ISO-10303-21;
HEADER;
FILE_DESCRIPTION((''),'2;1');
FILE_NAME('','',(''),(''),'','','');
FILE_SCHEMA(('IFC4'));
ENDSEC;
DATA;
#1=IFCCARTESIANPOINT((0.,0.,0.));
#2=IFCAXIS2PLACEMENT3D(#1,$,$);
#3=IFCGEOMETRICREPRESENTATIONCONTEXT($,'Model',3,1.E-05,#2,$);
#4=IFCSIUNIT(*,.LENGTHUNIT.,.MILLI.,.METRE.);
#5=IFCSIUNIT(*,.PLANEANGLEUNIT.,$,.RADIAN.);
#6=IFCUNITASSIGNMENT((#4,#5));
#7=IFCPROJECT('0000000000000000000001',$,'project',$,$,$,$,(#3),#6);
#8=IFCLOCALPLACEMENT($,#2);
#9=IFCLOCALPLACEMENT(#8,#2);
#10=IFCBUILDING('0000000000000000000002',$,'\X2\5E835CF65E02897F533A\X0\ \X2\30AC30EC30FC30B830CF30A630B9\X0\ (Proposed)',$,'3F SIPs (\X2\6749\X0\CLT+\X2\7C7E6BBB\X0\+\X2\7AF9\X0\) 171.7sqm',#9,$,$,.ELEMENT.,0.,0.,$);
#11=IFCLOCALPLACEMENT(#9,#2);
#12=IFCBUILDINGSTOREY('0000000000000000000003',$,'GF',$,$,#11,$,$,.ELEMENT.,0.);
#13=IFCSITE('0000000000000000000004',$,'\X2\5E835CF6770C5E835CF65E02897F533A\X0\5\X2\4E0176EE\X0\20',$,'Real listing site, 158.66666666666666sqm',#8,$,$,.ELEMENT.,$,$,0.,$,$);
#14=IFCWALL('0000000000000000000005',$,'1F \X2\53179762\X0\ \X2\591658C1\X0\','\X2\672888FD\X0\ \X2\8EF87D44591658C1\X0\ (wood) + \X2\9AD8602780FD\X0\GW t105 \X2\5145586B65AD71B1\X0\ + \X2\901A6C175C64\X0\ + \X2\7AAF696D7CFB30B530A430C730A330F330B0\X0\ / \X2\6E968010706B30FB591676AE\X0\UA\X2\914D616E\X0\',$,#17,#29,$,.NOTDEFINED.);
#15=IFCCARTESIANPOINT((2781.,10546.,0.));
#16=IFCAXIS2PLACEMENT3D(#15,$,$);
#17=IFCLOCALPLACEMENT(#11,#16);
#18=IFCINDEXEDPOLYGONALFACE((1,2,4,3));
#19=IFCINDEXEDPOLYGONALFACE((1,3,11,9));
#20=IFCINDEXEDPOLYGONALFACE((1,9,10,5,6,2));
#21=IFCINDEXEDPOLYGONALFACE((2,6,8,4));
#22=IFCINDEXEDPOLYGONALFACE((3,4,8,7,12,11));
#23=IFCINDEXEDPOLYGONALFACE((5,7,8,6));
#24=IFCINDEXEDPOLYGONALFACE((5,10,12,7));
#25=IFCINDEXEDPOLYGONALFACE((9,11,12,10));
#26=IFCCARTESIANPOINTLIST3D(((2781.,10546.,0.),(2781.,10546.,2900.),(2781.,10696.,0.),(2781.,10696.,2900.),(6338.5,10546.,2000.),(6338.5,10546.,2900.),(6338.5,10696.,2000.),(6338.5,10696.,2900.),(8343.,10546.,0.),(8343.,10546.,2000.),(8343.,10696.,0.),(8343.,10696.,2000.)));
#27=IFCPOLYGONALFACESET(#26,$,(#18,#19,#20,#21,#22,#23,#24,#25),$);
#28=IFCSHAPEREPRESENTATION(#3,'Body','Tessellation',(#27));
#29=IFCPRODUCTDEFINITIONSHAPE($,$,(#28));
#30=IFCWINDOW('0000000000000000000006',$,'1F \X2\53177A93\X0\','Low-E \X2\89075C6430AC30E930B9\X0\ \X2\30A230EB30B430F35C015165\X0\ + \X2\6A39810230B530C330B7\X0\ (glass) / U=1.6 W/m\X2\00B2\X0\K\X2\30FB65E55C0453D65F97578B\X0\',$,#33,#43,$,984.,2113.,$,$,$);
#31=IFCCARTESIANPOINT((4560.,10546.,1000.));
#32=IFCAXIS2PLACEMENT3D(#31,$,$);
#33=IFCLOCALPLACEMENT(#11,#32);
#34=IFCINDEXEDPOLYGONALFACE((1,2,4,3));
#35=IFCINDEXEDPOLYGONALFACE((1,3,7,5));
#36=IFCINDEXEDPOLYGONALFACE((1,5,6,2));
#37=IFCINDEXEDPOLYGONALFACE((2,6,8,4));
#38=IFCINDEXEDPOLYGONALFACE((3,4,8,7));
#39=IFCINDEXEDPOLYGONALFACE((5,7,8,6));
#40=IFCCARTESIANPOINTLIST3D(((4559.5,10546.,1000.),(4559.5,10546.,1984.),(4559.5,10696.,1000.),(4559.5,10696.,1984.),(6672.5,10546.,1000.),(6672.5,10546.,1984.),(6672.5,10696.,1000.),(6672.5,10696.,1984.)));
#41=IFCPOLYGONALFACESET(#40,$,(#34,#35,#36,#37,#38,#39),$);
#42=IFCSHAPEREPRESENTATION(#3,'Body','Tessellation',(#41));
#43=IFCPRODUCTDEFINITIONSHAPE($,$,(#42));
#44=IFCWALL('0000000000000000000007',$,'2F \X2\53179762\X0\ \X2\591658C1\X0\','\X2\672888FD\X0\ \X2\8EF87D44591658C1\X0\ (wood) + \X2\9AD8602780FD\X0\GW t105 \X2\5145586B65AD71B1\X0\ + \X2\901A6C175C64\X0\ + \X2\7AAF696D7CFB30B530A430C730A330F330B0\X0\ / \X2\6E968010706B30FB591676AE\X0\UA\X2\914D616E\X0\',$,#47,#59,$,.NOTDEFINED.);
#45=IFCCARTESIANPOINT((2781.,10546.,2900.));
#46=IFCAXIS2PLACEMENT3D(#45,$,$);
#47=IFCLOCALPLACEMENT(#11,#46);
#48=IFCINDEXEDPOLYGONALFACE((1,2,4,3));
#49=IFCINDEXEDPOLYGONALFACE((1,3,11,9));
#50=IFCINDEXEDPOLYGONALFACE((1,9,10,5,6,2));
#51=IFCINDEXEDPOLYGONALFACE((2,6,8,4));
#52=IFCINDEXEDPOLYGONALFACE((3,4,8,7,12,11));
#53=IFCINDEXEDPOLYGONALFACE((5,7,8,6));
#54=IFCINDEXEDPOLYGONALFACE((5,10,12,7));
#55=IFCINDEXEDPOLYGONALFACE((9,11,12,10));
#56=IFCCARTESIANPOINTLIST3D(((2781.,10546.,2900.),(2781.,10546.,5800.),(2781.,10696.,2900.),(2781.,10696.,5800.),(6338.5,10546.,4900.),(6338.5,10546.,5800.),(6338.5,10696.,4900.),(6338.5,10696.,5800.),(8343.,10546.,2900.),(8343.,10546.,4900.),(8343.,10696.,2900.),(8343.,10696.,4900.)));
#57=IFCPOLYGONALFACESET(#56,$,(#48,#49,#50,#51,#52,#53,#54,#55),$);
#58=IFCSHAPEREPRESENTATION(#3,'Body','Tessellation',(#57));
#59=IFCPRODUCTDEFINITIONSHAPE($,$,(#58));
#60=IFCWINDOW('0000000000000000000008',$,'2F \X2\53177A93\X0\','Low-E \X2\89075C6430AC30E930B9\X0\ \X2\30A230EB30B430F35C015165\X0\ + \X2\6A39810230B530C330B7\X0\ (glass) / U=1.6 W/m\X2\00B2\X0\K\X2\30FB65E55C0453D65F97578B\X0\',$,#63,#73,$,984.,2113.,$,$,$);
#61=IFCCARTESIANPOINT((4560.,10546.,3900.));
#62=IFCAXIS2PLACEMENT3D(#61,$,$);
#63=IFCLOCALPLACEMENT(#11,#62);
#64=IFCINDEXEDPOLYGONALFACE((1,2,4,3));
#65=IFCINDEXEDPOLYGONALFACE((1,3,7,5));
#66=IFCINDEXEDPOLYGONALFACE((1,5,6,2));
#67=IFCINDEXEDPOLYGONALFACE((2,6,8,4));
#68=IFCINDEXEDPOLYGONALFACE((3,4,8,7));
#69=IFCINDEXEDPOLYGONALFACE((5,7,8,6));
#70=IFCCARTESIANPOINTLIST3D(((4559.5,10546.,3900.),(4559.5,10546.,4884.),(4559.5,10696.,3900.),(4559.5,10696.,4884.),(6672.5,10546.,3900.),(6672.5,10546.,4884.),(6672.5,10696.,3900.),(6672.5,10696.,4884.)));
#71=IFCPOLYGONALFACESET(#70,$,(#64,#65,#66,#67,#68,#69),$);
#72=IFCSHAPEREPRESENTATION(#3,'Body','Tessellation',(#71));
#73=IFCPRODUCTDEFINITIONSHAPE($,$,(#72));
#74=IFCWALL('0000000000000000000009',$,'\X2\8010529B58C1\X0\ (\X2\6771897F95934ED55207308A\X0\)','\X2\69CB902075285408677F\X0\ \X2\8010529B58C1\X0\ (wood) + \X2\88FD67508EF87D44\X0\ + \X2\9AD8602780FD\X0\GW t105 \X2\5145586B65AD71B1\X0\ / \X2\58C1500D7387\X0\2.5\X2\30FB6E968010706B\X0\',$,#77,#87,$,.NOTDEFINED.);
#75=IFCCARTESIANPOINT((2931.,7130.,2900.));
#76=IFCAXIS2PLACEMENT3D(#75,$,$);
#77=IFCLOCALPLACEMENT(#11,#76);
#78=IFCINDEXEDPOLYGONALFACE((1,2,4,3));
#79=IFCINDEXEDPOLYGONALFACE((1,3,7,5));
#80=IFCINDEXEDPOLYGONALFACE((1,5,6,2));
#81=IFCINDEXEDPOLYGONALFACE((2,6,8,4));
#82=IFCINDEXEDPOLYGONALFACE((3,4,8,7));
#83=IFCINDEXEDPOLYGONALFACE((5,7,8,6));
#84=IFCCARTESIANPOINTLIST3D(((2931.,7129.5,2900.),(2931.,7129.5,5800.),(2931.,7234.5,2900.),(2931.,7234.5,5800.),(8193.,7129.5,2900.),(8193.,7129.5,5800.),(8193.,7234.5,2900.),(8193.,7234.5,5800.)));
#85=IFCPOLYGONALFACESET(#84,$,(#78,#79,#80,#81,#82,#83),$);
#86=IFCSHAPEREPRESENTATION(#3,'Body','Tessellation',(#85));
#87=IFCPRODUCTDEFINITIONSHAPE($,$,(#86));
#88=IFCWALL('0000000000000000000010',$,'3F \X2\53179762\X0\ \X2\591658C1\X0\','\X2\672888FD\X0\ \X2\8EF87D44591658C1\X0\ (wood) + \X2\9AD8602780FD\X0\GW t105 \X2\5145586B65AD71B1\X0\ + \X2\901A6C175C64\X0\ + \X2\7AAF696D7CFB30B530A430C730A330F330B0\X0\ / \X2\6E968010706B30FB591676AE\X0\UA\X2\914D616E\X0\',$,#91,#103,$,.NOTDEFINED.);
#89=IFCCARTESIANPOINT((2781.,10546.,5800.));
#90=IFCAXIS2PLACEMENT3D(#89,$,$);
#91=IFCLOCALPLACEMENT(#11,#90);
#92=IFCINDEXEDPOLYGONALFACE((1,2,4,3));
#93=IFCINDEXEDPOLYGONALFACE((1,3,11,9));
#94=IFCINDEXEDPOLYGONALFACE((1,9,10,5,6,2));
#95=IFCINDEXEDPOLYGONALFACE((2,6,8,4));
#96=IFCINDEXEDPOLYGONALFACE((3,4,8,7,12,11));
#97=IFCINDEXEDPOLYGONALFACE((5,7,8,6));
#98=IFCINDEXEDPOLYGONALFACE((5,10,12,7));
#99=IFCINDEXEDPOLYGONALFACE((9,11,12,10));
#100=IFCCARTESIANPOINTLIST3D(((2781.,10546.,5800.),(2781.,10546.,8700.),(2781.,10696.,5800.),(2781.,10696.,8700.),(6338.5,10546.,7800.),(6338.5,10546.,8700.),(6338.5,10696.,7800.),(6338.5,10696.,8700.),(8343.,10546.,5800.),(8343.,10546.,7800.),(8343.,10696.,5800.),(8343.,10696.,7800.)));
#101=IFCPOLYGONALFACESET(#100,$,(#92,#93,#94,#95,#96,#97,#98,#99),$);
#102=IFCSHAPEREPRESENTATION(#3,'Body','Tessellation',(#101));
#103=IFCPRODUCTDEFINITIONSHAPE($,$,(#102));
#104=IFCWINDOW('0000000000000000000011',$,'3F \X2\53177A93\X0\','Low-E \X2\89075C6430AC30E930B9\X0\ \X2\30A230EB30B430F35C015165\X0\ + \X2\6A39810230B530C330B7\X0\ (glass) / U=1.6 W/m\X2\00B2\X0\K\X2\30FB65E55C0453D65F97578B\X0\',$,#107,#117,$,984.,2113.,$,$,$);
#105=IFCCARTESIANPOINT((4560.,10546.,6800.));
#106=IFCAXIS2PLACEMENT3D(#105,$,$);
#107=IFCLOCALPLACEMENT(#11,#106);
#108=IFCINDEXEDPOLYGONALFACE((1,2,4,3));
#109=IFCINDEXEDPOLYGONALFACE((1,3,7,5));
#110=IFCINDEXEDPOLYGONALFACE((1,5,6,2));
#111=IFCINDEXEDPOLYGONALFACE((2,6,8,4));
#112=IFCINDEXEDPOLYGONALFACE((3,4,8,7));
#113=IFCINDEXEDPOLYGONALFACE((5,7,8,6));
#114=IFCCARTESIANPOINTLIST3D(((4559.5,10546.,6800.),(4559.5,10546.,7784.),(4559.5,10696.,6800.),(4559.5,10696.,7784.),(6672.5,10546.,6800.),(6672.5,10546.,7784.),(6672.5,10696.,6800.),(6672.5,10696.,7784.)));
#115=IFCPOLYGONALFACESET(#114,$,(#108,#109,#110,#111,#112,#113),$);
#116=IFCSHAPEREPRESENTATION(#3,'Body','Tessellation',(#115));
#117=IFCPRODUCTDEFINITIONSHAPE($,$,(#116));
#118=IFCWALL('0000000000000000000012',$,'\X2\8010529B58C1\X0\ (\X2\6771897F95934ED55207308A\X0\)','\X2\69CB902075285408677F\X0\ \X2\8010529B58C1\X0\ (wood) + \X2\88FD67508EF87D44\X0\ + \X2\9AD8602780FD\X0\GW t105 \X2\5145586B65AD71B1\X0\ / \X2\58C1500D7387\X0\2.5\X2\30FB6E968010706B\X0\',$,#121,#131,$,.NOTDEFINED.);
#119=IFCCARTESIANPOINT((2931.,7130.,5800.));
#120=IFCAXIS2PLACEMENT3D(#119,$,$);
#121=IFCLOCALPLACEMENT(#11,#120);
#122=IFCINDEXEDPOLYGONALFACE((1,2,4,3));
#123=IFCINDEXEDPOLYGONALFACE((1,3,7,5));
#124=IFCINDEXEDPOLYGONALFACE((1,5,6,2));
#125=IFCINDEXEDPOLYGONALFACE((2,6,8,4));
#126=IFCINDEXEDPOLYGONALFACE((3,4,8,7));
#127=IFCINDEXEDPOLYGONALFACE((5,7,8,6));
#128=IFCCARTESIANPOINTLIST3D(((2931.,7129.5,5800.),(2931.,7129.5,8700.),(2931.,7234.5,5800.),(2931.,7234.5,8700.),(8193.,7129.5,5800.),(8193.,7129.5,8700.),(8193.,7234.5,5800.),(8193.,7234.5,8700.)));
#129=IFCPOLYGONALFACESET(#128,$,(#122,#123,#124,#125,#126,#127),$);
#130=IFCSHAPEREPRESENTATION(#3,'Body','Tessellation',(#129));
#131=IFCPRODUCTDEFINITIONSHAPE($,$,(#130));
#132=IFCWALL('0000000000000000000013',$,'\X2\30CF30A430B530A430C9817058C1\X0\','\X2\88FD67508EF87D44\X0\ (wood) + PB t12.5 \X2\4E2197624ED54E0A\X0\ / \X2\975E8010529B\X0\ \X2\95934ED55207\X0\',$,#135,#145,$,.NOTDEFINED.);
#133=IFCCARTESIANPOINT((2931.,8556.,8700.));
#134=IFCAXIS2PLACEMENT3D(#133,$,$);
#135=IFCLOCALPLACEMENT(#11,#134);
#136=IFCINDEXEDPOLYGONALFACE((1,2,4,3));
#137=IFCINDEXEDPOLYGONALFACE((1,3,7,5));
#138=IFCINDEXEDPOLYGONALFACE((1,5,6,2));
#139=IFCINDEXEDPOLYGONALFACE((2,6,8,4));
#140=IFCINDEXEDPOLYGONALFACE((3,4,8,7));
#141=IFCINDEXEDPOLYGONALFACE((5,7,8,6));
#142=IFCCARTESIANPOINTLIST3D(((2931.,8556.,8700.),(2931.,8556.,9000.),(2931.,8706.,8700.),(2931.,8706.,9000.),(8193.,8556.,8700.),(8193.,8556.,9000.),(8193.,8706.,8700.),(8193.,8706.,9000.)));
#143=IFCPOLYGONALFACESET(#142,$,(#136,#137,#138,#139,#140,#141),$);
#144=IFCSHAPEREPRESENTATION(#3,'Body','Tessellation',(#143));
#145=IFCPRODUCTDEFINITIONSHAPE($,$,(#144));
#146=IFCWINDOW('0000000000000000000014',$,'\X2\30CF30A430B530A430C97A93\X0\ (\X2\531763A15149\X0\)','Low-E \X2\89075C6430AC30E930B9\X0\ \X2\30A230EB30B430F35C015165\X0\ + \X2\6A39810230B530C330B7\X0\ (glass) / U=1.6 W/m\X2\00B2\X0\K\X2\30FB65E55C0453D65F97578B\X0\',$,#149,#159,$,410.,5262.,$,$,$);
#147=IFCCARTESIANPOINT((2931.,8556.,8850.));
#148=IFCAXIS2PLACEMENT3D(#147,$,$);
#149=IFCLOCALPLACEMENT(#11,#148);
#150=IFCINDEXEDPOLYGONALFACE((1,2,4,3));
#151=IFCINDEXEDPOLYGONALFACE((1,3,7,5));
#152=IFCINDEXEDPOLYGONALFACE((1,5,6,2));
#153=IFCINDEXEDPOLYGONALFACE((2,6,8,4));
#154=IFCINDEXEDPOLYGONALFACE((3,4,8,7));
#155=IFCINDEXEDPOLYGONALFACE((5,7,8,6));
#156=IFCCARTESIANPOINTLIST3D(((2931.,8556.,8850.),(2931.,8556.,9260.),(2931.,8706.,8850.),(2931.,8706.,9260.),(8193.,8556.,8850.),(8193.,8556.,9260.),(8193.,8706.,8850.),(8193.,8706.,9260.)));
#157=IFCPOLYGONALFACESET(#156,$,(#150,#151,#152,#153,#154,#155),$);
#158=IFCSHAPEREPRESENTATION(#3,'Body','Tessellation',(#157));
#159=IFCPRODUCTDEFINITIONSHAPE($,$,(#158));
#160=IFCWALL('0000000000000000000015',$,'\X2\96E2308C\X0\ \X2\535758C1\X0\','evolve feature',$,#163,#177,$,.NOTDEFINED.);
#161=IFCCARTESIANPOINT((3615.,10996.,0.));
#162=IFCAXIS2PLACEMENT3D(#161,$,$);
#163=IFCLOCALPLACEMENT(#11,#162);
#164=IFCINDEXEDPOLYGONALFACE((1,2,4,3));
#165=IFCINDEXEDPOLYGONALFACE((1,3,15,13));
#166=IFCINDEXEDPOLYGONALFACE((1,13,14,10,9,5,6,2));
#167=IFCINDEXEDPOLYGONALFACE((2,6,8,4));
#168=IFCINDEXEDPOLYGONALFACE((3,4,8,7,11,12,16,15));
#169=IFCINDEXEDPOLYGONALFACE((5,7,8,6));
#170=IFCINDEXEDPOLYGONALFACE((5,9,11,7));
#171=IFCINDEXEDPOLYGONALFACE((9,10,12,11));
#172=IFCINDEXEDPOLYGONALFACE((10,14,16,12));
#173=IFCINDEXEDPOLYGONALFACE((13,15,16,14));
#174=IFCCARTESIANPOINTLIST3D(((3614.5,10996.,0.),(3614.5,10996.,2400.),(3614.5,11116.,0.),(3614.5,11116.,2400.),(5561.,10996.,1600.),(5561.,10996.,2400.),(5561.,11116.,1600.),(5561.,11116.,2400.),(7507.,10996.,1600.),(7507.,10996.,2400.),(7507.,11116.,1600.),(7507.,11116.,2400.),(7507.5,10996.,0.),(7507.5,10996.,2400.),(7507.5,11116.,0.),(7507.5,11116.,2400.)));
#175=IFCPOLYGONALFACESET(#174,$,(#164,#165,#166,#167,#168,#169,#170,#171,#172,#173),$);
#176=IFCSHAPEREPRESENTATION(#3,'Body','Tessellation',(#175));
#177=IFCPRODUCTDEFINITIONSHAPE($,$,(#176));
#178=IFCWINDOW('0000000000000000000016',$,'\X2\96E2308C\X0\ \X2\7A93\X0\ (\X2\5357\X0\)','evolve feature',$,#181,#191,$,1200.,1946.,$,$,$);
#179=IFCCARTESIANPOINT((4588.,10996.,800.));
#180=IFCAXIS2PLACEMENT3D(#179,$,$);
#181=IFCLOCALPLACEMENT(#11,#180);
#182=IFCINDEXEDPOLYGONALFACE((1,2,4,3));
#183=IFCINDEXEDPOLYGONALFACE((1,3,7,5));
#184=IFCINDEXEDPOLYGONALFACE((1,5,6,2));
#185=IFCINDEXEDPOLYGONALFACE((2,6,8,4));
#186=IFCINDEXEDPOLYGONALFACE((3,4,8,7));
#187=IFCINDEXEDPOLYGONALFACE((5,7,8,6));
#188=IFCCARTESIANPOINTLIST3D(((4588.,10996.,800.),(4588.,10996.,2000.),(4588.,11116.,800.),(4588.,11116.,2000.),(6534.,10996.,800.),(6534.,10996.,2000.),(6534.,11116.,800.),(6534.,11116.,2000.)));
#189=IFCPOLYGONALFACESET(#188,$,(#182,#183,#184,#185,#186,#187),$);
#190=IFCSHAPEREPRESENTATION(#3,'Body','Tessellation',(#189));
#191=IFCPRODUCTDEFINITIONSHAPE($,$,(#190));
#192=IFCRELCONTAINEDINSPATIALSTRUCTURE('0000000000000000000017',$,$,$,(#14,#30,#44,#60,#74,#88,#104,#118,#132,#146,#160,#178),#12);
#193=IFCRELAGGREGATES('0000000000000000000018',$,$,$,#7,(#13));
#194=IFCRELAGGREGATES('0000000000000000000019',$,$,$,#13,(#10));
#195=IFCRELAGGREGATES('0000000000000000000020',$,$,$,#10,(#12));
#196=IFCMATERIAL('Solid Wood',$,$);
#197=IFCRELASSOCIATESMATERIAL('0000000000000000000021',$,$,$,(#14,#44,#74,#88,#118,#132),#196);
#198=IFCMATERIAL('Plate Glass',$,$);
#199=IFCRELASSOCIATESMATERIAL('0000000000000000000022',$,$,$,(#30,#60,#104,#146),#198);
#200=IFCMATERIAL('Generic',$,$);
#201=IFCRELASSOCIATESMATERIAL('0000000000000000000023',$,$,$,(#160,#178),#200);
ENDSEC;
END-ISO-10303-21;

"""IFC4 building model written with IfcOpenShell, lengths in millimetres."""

from ifc_helpers import new_model, si_unit, frame, frame_2d, origin, place, context, project, spatial, rectangle, extrude, material, element, fill, save


model = new_model("IFC4")

# Units and contexts
model_context = context("Model", 3, precision=1e-05, world=origin())
ifc_project = project(units=[si_unit("LENGTHUNIT", "METRE", prefix="MILLI"), si_unit("PLANEANGLEUNIT", "RADIAN")], contexts=[model_context])

# Site, building, storey
site_placement = place(None, origin())
site = spatial("IfcSite", under=ifc_project, at=site_placement, Name="広島県広島市西区5丁目20", ObjectType="Real listing site, 158.66666666666666sqm", CompositionType="ELEMENT", RefElevation=0.0)
building_placement = place(site_placement, origin())
building = spatial("IfcBuilding", under=site, at=building_placement, Name="広島市西区 ガレージハウス (Proposed)", ObjectType="3F SIPs (杉CLT+籾殻+竹) 171.7sqm", CompositionType="ELEMENT", ElevationOfRefHeight=0.0, ElevationOfTerrain=0.0)
storey_placement = place(building_placement, origin())
storey = spatial("IfcBuildingStorey", under=building, at=storey_placement, Name="GF", CompositionType="ELEMENT", Elevation=0.0)

# Shared definitions
ifc_material_1 = material(Name="Generic")

# Wall, opening, window
ifc_material_2 = material(Name="Solid Wood")
wall_1_placement = place(storey_placement, frame((2781.0, 10546.0, 0.0)))
wall_1 = element("IfcWall", 1, at=wall_1_placement, inside=storey, material=ifc_material_2, Name="1F 北面 外壁", Description="木製 軸組外壁 (wood) + 高性能GW t105 充填断熱 + 通気層 + 窯業系サイディング / 準耐火・外皮UA配慮", PredefinedType="NOTDEFINED", context=model_context, shape_type="SweptSolid", body=[
    extrude(rectangle(XDim=5562.0, YDim=150.0, at=frame_2d((2781.0, 75.0))), frame((2781.0, 10546.0, 0.0)), (0.0, 0.0, 1.0), 2900.0),
])
opening_1_placement = place(storey_placement, frame((4560.0, 10546.0, 1000.0)))
opening_1 = element("IfcOpeningElement", 2, at=opening_1_placement, cuts=wall_1, PredefinedType="NOTDEFINED", context=model_context, shape_type="SweptSolid", body=[
    extrude(rectangle(XDim=2113.0, YDim=150.0, at=frame_2d((1056.0, 75.0))), frame((4560.0, 10546.0, 1000.0)), (0.0, 0.0, 1.0), 984.0),
])
ifc_material_3 = material(Name="Plate Glass")
window_1_placement = place(storey_placement, frame((4560.0, 10546.0, 1000.0)))
window_1 = element("IfcWindow", 3, at=window_1_placement, inside=storey, material=ifc_material_3, Name="1F 北窓", Description="Low-E 複層ガラス アルゴン封入 + 樹脂サッシ (glass) / U=1.6 W/m²K・日射取得型", OverallHeight=984.0, OverallWidth=2113.0, context=model_context, shape_type="SweptSolid", body=[
    extrude(rectangle(XDim=2113.0, YDim=150.0, at=frame_2d((1056.0, 75.0))), frame((4560.0, 10546.0, 1000.0)), (0.0, 0.0, 1.0), 984.0),
])
fill(opening_1, window_1)

# Wall, opening, window
wall_2_placement = place(storey_placement, frame((2781.0, 10546.0, 2900.0)))
wall_2 = element("IfcWall", 4, at=wall_2_placement, inside=storey, material=ifc_material_2, Name="2F 北面 外壁", Description="木製 軸組外壁 (wood) + 高性能GW t105 充填断熱 + 通気層 + 窯業系サイディング / 準耐火・外皮UA配慮", PredefinedType="NOTDEFINED", context=model_context, shape_type="SweptSolid", body=[
    extrude(rectangle(XDim=5562.0, YDim=150.0, at=frame_2d((2781.0, 75.0))), frame((2781.0, 10546.0, 2900.0)), (0.0, 0.0, 1.0), 2900.0),
])
opening_2_placement = place(storey_placement, frame((4560.0, 10546.0, 3900.0)))
opening_2 = element("IfcOpeningElement", 5, at=opening_2_placement, cuts=wall_2, PredefinedType="NOTDEFINED", context=model_context, shape_type="SweptSolid", body=[
    extrude(rectangle(XDim=2113.0, YDim=150.0, at=frame_2d((1056.0, 75.0))), frame((4560.0, 10546.0, 3900.0)), (0.0, 0.0, 1.0), 984.0),
])
window_2_placement = place(storey_placement, frame((4560.0, 10546.0, 3900.0)))
window_2 = element("IfcWindow", 6, at=window_2_placement, inside=storey, material=ifc_material_3, Name="2F 北窓", Description="Low-E 複層ガラス アルゴン封入 + 樹脂サッシ (glass) / U=1.6 W/m²K・日射取得型", OverallHeight=984.0, OverallWidth=2113.0, context=model_context, shape_type="SweptSolid", body=[
    extrude(rectangle(XDim=2113.0, YDim=150.0, at=frame_2d((1056.0, 75.0))), frame((4560.0, 10546.0, 3900.0)), (0.0, 0.0, 1.0), 984.0),
])
fill(opening_2, window_2)

# Wall
wall_3_placement = place(storey_placement, frame((2931.0, 7130.0, 2900.0)))
element("IfcWall", 7, at=wall_3_placement, inside=storey, material=ifc_material_2, Name="耐力壁 (東西間仕切り)", Description="構造用合板 耐力壁 (wood) + 製材軸組 + 高性能GW t105 充填断熱 / 壁倍率2.5・準耐火", PredefinedType="NOTDEFINED", context=model_context, shape_type="SweptSolid", body=[
    extrude(rectangle(XDim=5262.0, YDim=105.0, at=frame_2d((2631.0, 52.0))), frame((2931.0, 7130.0, 2900.0)), (0.0, 0.0, 1.0), 2900.0),
])

# Wall, opening, window
wall_4_placement = place(storey_placement, frame((2781.0, 10546.0, 5800.0)))
wall_4 = element("IfcWall", 8, at=wall_4_placement, inside=storey, material=ifc_material_2, Name="3F 北面 外壁", Description="木製 軸組外壁 (wood) + 高性能GW t105 充填断熱 + 通気層 + 窯業系サイディング / 準耐火・外皮UA配慮", PredefinedType="NOTDEFINED", context=model_context, shape_type="SweptSolid", body=[
    extrude(rectangle(XDim=5562.0, YDim=150.0, at=frame_2d((2781.0, 75.0))), frame((2781.0, 10546.0, 5800.0)), (0.0, 0.0, 1.0), 2900.0),
])
opening_3_placement = place(storey_placement, frame((4560.0, 10546.0, 6800.0)))
opening_3 = element("IfcOpeningElement", 9, at=opening_3_placement, cuts=wall_4, PredefinedType="NOTDEFINED", context=model_context, shape_type="SweptSolid", body=[
    extrude(rectangle(XDim=2113.0, YDim=150.0, at=frame_2d((1056.0, 75.0))), frame((4560.0, 10546.0, 6800.0)), (0.0, 0.0, 1.0), 984.0),
])
window_3_placement = place(storey_placement, frame((4560.0, 10546.0, 6800.0)))
window_3 = element("IfcWindow", 10, at=window_3_placement, inside=storey, material=ifc_material_3, Name="3F 北窓", Description="Low-E 複層ガラス アルゴン封入 + 樹脂サッシ (glass) / U=1.6 W/m²K・日射取得型", OverallHeight=984.0, OverallWidth=2113.0, context=model_context, shape_type="SweptSolid", body=[
    extrude(rectangle(XDim=2113.0, YDim=150.0, at=frame_2d((1056.0, 75.0))), frame((4560.0, 10546.0, 6800.0)), (0.0, 0.0, 1.0), 984.0),
])
fill(opening_3, window_3)

# Wall
wall_5_placement = place(storey_placement, frame((2931.0, 7130.0, 5800.0)))
element("IfcWall", 11, at=wall_5_placement, inside=storey, material=ifc_material_2, Name="耐力壁 (東西間仕切り)", Description="構造用合板 耐力壁 (wood) + 製材軸組 + 高性能GW t105 充填断熱 / 壁倍率2.5・準耐火", PredefinedType="NOTDEFINED", context=model_context, shape_type="SweptSolid", body=[
    extrude(rectangle(XDim=5262.0, YDim=105.0, at=frame_2d((2631.0, 52.0))), frame((2931.0, 7130.0, 5800.0)), (0.0, 0.0, 1.0), 2900.0),
])

# Walls, openings, windows
wall_6_placement = place(storey_placement, frame((2931.0, 8556.0, 8700.0)))
wall_6 = element("IfcWall", 12, at=wall_6_placement, inside=storey, material=ifc_material_2, Name="ハイサイド腰壁", Description="製材軸組 (wood) + PB t12.5 両面仕上 / 非耐力 間仕切", PredefinedType="NOTDEFINED", context=model_context, shape_type="SweptSolid", body=[
    extrude(rectangle(XDim=5262.0, YDim=150.0, at=frame_2d((2631.0, 75.0))), frame((2931.0, 8556.0, 8700.0)), (0.0, 0.0, 1.0), 700.0),
])
opening_4_placement = place(storey_placement, frame((2931.0, 8556.0, 8850.0)))
opening_4 = element("IfcOpeningElement", 13, at=opening_4_placement, cuts=wall_6, PredefinedType="NOTDEFINED", context=model_context, shape_type="SweptSolid", body=[
    extrude(rectangle(XDim=5262.0, YDim=150.0, at=frame_2d((2631.0, 75.0))), frame((2931.0, 8556.0, 8850.0)), (0.0, 0.0, 1.0), 410.0),
])
window_4_placement = place(storey_placement, frame((2931.0, 8556.0, 8850.0)))
window_4 = element("IfcWindow", 14, at=window_4_placement, inside=storey, material=ifc_material_3, Name="ハイサイド窓 (北採光)", Description="Low-E 複層ガラス アルゴン封入 + 樹脂サッシ (glass) / U=1.6 W/m²K・日射取得型", OverallHeight=410.0, OverallWidth=5262.0, context=model_context, shape_type="SweptSolid", body=[
    extrude(rectangle(XDim=5262.0, YDim=150.0, at=frame_2d((2631.0, 75.0))), frame((2931.0, 8556.0, 8850.0)), (0.0, 0.0, 1.0), 410.0),
])
fill(opening_4, window_4)
wall_7_placement = place(storey_placement, frame((3615.0, 10996.0, 0.0)))
wall_7 = element("IfcWall", 15, at=wall_7_placement, inside=storey, material=ifc_material_1, Name="離れ 南壁", Description="evolve feature", PredefinedType="NOTDEFINED", context=model_context, shape_type="SweptSolid", body=[
    extrude(rectangle(XDim=3893.0, YDim=120.0, at=frame_2d((1946.0, 60.0))), frame((3615.0, 10996.0, 0.0)), (0.0, 0.0, 1.0), 2400.0),
])
opening_5_placement = place(storey_placement, frame((4588.0, 10996.0, 800.0)))
opening_5 = element("IfcOpeningElement", 16, at=opening_5_placement, cuts=wall_7, PredefinedType="NOTDEFINED", context=model_context, shape_type="SweptSolid", body=[
    extrude(rectangle(XDim=1946.0, YDim=120.0, at=frame_2d((973.0, 60.0))), frame((4588.0, 10996.0, 800.0)), (0.0, 0.0, 1.0), 1200.0),
])
window_5_placement = place(storey_placement, frame((4588.0, 10996.0, 800.0)))
window_5 = element("IfcWindow", 17, at=window_5_placement, inside=storey, material=ifc_material_1, Name="離れ 窓 (南)", Description="evolve feature", OverallHeight=1200.0, OverallWidth=1946.0, context=model_context, shape_type="SweptSolid", body=[
    extrude(rectangle(XDim=1946.0, YDim=120.0, at=frame_2d((973.0, 60.0))), frame((4588.0, 10996.0, 800.0)), (0.0, 0.0, 1.0), 1200.0),
])
fill(opening_5, window_5)

save(model, "model.ifc")
